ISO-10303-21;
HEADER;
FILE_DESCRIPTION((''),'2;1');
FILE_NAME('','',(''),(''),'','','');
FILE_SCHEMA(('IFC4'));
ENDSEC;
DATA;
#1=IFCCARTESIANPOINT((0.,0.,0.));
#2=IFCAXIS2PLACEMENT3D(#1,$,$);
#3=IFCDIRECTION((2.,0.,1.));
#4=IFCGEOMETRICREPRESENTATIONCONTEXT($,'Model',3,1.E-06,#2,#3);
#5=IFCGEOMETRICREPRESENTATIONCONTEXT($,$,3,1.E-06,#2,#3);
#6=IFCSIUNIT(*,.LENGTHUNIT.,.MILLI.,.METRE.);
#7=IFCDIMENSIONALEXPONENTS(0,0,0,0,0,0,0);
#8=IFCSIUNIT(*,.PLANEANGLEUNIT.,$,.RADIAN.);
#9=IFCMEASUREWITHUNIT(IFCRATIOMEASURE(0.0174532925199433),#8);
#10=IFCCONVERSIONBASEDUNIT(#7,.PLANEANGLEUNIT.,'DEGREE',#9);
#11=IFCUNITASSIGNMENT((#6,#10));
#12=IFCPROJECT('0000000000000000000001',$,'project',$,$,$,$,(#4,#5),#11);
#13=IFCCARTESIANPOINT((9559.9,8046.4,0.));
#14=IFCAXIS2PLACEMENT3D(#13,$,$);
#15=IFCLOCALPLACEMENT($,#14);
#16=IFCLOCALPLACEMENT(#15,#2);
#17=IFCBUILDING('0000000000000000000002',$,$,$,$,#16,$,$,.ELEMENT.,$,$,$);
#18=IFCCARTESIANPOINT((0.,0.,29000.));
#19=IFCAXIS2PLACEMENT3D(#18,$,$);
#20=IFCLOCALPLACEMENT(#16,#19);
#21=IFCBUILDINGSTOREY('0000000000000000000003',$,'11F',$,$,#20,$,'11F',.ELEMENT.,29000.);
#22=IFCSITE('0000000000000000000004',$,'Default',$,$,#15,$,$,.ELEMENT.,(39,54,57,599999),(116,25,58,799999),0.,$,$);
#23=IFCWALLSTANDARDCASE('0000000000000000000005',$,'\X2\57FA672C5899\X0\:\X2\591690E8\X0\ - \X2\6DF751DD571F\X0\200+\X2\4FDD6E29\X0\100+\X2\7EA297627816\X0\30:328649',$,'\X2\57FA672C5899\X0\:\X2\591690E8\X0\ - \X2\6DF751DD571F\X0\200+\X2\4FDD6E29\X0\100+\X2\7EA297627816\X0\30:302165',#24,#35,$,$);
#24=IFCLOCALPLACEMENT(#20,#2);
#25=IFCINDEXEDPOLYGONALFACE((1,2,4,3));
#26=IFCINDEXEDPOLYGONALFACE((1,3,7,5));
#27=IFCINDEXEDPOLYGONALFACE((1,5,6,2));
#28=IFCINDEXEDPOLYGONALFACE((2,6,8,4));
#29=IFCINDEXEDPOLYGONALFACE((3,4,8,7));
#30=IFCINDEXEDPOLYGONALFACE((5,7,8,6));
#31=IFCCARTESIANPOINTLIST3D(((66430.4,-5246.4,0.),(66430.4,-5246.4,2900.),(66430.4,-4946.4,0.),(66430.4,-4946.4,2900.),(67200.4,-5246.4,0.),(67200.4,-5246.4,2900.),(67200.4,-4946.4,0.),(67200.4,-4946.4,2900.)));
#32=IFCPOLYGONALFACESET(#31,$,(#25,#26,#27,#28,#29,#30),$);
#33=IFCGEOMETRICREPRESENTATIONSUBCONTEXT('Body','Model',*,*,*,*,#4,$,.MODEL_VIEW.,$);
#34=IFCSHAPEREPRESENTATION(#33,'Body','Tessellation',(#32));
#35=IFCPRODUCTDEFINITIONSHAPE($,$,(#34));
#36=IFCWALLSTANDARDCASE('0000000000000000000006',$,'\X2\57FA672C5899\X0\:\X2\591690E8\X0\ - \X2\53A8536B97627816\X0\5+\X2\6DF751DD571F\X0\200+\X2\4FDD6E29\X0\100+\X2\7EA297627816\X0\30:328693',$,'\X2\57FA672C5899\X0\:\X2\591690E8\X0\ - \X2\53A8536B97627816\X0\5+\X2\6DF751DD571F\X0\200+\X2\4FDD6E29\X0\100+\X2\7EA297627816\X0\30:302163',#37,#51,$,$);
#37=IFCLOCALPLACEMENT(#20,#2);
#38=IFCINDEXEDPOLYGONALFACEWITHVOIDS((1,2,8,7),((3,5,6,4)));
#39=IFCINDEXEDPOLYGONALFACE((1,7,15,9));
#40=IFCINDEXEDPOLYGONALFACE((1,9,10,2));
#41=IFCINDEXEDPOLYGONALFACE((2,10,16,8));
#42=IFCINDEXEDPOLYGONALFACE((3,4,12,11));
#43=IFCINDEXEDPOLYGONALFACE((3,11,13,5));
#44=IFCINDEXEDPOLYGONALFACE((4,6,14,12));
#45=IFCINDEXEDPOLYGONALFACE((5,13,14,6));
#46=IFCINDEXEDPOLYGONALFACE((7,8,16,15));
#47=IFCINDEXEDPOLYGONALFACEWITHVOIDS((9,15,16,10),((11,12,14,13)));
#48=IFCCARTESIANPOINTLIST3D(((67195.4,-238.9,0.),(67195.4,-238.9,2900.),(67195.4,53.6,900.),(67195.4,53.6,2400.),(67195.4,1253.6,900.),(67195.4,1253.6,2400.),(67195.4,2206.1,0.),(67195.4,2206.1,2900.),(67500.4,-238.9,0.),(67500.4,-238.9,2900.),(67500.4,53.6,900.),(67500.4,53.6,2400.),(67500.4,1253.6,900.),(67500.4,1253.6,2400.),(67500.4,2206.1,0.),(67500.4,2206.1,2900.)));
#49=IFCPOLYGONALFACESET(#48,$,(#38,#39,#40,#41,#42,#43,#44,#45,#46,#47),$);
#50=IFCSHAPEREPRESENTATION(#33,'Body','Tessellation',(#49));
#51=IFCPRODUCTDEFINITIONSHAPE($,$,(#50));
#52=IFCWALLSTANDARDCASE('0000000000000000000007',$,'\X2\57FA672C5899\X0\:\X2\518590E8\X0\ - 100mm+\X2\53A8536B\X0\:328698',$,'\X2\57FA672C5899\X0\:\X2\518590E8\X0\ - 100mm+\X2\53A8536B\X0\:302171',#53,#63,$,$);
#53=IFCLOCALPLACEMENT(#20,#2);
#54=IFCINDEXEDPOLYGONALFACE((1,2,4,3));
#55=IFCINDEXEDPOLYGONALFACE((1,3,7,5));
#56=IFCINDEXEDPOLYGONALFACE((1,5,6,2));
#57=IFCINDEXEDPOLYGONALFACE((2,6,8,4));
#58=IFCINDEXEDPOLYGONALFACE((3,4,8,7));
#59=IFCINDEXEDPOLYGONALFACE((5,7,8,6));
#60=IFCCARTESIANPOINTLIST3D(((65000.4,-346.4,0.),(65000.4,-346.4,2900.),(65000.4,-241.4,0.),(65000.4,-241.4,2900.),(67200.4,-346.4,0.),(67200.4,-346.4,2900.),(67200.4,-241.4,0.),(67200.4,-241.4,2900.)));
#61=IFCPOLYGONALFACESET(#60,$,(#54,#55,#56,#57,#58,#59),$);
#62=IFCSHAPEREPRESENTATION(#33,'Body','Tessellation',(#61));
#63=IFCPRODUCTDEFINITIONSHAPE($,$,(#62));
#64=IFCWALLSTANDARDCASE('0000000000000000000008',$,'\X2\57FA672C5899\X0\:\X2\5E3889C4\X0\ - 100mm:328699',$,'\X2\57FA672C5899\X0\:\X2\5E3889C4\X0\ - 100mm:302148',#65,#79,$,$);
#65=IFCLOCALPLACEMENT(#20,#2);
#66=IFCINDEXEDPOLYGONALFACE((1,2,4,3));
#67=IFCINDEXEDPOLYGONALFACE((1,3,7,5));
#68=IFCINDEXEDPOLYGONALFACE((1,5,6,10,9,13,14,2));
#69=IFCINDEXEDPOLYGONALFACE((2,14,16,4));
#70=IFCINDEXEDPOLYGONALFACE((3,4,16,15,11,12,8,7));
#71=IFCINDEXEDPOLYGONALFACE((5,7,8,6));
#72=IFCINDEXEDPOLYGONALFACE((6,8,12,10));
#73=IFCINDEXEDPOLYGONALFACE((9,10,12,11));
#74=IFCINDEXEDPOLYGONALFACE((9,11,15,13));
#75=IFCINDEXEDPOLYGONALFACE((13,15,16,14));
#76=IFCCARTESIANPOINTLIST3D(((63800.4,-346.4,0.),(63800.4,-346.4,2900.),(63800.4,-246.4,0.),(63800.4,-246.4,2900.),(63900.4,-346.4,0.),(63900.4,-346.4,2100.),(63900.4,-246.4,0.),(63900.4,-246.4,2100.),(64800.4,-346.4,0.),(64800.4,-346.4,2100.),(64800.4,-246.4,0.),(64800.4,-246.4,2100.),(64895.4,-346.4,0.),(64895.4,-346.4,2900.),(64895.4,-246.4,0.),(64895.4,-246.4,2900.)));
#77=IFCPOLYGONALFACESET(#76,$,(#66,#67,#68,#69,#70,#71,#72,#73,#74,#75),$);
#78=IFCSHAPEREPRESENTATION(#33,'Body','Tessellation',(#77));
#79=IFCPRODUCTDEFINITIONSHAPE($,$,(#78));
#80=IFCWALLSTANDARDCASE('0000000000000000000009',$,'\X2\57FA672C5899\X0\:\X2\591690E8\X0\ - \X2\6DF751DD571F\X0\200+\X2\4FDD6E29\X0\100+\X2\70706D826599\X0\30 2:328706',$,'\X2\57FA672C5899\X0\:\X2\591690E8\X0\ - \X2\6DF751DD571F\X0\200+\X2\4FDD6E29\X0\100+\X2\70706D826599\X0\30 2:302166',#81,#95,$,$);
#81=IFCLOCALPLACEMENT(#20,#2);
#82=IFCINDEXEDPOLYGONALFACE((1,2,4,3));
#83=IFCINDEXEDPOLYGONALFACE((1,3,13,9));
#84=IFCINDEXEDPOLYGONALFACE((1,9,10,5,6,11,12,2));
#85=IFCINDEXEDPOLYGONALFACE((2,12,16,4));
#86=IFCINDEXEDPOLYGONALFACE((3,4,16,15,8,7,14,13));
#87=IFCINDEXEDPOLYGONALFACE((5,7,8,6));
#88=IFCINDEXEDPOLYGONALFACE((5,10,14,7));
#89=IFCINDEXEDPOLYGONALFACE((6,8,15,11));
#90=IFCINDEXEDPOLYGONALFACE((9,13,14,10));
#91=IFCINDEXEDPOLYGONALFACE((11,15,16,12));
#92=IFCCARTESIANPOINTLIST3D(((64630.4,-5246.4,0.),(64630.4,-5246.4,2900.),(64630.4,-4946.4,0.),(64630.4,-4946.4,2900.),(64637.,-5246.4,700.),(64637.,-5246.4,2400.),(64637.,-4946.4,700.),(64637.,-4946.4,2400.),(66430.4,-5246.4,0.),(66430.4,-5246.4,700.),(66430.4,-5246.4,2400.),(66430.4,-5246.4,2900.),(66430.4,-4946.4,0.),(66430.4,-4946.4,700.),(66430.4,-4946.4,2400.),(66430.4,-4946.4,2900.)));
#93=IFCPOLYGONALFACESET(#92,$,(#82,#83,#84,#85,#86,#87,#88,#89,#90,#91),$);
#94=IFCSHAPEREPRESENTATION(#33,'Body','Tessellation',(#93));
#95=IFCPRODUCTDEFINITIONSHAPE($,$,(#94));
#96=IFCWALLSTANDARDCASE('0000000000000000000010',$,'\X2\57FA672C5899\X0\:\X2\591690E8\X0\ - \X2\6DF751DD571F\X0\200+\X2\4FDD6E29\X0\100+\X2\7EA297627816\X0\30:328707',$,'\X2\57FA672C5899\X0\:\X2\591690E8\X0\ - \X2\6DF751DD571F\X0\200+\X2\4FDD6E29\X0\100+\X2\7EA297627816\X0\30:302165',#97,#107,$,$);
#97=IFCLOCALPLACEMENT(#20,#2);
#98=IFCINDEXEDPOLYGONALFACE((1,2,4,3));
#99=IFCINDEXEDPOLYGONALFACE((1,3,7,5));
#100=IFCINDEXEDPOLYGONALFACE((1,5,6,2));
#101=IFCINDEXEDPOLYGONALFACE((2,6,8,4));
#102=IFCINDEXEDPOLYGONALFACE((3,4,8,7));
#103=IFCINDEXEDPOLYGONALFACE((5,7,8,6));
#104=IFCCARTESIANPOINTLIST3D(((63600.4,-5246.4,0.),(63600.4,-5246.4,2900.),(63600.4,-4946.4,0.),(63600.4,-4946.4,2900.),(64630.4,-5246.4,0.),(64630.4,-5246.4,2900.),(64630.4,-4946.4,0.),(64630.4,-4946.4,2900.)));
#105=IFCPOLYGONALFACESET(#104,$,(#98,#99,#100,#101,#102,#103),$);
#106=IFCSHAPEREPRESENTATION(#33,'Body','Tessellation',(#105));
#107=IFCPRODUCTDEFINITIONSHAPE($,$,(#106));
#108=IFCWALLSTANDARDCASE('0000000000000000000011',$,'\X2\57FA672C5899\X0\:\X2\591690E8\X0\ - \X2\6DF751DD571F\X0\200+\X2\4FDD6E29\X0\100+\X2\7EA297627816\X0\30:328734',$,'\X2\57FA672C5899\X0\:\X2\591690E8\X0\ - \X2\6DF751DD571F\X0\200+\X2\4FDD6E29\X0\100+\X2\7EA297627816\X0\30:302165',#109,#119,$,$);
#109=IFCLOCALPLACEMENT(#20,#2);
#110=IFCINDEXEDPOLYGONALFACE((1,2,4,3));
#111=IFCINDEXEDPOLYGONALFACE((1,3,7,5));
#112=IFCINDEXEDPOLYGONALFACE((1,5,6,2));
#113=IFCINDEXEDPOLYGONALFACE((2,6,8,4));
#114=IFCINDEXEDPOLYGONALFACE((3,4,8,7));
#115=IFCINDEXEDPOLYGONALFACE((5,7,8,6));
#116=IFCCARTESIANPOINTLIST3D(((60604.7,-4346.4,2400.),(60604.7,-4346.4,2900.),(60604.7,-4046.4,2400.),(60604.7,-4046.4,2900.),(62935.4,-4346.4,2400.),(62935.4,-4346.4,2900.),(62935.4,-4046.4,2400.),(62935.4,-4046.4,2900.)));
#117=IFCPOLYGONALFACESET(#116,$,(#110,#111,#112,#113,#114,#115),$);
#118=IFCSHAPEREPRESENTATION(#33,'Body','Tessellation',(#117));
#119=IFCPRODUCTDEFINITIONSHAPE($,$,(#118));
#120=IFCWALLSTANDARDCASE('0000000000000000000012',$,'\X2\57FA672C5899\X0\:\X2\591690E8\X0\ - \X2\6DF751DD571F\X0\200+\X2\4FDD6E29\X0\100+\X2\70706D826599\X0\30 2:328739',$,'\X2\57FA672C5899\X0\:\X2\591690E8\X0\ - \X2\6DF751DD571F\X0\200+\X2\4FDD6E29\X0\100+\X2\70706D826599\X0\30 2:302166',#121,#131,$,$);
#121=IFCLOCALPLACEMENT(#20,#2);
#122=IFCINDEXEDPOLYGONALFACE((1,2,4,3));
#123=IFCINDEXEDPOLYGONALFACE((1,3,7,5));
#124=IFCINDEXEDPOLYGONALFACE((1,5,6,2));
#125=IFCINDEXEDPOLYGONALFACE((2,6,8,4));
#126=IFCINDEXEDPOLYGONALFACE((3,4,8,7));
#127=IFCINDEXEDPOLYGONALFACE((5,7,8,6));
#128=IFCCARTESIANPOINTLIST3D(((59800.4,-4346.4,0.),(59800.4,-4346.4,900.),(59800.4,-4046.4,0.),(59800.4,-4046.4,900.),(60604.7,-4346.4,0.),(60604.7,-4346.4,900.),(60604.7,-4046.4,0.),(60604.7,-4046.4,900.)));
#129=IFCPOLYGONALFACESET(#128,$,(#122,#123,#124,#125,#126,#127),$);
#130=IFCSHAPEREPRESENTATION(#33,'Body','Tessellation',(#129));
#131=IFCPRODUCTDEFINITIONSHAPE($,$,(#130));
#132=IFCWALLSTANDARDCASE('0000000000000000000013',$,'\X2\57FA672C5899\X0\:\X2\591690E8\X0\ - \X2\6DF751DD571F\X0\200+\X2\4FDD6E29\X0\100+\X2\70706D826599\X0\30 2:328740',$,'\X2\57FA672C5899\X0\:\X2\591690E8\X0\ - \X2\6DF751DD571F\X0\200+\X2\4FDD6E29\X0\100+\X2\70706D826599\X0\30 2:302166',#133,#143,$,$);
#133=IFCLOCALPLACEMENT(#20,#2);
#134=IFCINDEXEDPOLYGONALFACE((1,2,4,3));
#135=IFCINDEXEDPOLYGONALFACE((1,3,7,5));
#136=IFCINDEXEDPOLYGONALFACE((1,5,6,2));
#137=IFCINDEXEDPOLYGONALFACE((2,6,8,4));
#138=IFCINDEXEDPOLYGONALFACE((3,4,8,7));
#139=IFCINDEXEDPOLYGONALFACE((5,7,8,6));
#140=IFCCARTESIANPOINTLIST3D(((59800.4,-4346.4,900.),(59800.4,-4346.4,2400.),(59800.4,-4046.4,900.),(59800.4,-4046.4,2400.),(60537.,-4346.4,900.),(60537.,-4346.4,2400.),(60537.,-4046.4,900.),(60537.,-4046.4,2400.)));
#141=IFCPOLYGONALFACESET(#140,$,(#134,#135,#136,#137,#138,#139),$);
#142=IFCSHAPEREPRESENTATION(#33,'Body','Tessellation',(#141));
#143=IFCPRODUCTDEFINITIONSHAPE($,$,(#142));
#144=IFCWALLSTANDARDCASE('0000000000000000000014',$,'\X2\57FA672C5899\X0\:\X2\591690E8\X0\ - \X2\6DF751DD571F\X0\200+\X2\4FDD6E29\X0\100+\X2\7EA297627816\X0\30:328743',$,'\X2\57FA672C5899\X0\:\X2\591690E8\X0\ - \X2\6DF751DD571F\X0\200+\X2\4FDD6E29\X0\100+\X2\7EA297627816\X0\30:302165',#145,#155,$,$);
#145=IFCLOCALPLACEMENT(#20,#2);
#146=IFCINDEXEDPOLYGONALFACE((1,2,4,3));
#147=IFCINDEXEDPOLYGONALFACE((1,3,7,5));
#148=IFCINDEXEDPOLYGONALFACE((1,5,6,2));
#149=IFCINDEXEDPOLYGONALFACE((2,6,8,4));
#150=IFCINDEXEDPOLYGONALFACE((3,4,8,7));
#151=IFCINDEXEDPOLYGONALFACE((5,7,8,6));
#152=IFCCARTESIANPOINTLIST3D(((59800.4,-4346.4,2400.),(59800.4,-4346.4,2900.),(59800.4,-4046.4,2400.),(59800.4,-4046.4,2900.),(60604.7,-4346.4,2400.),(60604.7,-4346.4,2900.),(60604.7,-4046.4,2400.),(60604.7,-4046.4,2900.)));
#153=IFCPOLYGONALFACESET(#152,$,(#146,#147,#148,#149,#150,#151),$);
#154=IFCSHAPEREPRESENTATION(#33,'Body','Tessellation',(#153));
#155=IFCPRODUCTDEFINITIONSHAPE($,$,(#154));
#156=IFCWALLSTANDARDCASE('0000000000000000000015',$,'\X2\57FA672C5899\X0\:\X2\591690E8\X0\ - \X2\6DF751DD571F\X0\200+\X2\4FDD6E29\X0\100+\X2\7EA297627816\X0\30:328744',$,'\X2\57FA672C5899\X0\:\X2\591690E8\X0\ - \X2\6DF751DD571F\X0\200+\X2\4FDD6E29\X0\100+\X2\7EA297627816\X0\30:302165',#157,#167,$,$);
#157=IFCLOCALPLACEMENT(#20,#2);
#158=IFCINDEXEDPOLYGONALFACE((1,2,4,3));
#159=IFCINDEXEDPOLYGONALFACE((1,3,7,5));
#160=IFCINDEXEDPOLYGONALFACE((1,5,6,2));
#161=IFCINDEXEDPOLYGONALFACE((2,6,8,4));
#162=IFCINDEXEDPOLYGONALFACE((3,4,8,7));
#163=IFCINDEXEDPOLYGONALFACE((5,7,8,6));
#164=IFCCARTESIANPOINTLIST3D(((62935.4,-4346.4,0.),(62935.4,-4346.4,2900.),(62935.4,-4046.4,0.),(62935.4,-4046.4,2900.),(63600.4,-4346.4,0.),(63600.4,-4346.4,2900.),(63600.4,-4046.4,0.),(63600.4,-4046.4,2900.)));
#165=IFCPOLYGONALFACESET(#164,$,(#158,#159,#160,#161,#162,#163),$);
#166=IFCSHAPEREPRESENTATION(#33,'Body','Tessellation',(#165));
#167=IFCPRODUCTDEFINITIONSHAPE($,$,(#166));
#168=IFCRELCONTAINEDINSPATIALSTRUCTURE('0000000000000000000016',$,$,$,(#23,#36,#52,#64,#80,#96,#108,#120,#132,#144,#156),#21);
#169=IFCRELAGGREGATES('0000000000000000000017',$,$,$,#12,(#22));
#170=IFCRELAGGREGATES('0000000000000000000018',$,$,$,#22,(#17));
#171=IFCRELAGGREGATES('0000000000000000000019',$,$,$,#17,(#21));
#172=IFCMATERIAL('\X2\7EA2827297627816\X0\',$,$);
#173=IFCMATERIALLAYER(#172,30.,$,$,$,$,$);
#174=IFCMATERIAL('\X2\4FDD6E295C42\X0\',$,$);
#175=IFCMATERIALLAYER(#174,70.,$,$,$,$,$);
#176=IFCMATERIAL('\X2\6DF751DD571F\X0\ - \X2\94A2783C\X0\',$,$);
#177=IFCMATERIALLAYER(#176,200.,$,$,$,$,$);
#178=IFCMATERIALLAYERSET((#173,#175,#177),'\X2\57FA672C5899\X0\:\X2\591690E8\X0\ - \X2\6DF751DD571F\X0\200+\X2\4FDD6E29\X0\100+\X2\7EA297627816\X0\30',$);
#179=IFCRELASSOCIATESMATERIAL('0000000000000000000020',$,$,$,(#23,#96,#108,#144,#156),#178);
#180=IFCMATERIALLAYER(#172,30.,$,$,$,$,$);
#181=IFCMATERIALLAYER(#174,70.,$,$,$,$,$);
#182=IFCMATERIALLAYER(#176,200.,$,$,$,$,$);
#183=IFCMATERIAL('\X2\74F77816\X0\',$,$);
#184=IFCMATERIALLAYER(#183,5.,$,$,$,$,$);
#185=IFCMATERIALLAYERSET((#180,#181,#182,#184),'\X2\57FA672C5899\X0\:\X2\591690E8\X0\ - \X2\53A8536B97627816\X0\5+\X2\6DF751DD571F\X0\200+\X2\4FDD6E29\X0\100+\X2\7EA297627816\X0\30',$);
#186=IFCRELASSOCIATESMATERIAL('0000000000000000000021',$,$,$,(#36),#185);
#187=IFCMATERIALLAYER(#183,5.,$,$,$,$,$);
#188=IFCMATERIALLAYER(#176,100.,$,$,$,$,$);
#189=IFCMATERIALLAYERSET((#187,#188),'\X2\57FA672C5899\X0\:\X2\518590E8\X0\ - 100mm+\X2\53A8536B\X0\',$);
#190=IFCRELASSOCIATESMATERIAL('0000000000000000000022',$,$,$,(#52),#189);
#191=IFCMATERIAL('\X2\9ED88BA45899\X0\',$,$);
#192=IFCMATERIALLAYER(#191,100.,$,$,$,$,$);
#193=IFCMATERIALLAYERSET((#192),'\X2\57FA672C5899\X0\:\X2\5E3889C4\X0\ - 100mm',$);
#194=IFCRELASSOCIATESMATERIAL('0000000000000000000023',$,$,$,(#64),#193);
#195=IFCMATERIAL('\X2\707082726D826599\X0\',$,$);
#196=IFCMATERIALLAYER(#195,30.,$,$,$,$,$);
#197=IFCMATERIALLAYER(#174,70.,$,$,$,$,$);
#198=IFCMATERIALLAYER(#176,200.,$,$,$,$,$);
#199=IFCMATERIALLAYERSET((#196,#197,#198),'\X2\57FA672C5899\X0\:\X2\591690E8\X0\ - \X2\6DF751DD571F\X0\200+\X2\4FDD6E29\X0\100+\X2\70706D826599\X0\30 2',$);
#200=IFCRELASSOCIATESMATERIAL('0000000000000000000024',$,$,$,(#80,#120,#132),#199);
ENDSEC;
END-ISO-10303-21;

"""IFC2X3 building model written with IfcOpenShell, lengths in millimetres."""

from ifc_helpers import new_model, entity, si_unit, converted_unit, direction, frame, frame_2d, origin, place, context, subcontext, project, spatial, rectangle, extrude, material, layer, layer_set, layer_usage, element, save


model = new_model("IFC2X3")

# Units and contexts
model_context = context("Model", 3, precision=1e-06, world=origin(), true_north=direction((2.0, 0.0, 1.0)))
context_of_model = context(None, 3, precision=1e-06, world=origin(), true_north=direction((2.0, 0.0, 1.0)))
body_context = subcontext(model_context, "Body", "Model", "MODEL_VIEW")
ifc_project = project(units=[si_unit("LENGTHUNIT", "METRE", prefix="MILLI"), converted_unit("PLANEANGLEUNIT", "DEGREE", entity("IfcRatioMeasure", 0.0174532925199433), si_unit("PLANEANGLEUNIT", "RADIAN"), dimensions=[0, 0, 0, 0, 0, 0, 0])], contexts=[model_context, context_of_model])

# Site, building, storey
site_placement = place(None, frame((9559.9, 8046.4, 0.0)))
site = spatial("IfcSite", under=ifc_project, at=site_placement, Name="Default", CompositionType="ELEMENT", RefLatitude=(39, 54, 57, 599999), RefLongitude=(116, 25, 58, 799999), RefElevation=0.0)
building_placement = place(site_placement, origin())
building = spatial("IfcBuilding", under=site, at=building_placement, CompositionType="ELEMENT")
storey_placement = place(building_placement, frame((0.0, 0.0, 29000.0)))
storey = spatial("IfcBuildingStorey", under=building, at=storey_placement, Name="11F", LongName="11F", CompositionType="ELEMENT", Elevation=29000.0)

# Shared definitions
ifc_material_1 = material(Name="默认墙")

# Shared definitions
ifc_material_2 = material(Name="保温层")
ifc_material_3 = material(Name="混凝土 - 钢砼")
ifc_material_4 = material(Name="灰色涂料")
ifc_layer_1 = layer(ifc_material_4, 30.0)
ifc_layer_2 = layer(ifc_material_2, 70.0)
ifc_layer_3 = layer(ifc_material_3, 200.0)
ifc_layer_set_1 = layer_set([ifc_layer_1, ifc_layer_2, ifc_layer_3], Name="基本墙:外部 - 混凝土200+保温100+灰涂料30 2")

# Shared definitions
ifc_material_5 = material(Name="红色面砖")
ifc_layer_4 = layer(ifc_material_5, 30.0)
ifc_layer_5 = layer(ifc_material_2, 70.0)
ifc_layer_6 = layer(ifc_material_3, 200.0)
ifc_layer_set_2 = layer_set([ifc_layer_4, ifc_layer_5, ifc_layer_6], Name="基本墙:外部 - 混凝土200+保温100+红面砖30")

# Wall
ifc_layer_usage_1 = layer_usage(ifc_layer_set_2, "AXIS2", "NEGATIVE", 150.0)
wall_1_placement = place(storey_placement, frame((67200.4, -5096.4, 0.0), z_axis=(0.0, 0.0, 1.0), x_axis=(-1.0, 0.0, 0.0)))
element("IfcWallStandardCase", 1, at=wall_1_placement, inside=storey, material=ifc_layer_usage_1, Name="基本墙:外部 - 混凝土200+保温100+红面砖30:328649", ObjectType="基本墙:外部 - 混凝土200+保温100+红面砖30:302165", context=body_context, shape_type="SweptSolid", body=[
    extrude(rectangle(XDim=770.0, YDim=300.0, at=frame_2d((385.0, 0.0), x_axis=(-1.0, 0.0))), origin(), (0.0, 0.0, 1.0), 2900.0),
])

# Wall, opening
ifc_layer_7 = layer(ifc_material_5, 30.0)
ifc_layer_8 = layer(ifc_material_2, 70.0)
ifc_layer_9 = layer(ifc_material_3, 200.0)
ifc_material_6 = material(Name="瓷砖")
ifc_layer_10 = layer(ifc_material_6, 5.0)
ifc_layer_set_3 = layer_set([ifc_layer_7, ifc_layer_8, ifc_layer_9, ifc_layer_10], Name="基本墙:外部 - 厨卫面砖5+混凝土200+保温100+红面砖30")
ifc_layer_usage_2 = layer_usage(ifc_layer_set_3, "AXIS2", "POSITIVE", -152.5)
wall_2_placement = place(storey_placement, frame((67347.9, -238.9, 0.0), z_axis=(0.0, 0.0, 1.0), x_axis=(0.0, 1.0, 0.0)))
wall_2 = element("IfcWallStandardCase", 2, at=wall_2_placement, inside=storey, material=ifc_layer_usage_2, Name="基本墙:外部 - 厨卫面砖5+混凝土200+保温100+红面砖30:328693", ObjectType="基本墙:外部 - 厨卫面砖5+混凝土200+保温100+红面砖30:302163", context=body_context, shape_type="SweptSolid", body=[
    extrude(rectangle(XDim=2445.0, YDim=305.0, at=frame_2d((1222.5, 0.0), x_axis=(-1.0, 0.0))), origin(), (0.0, 0.0, 1.0), 2900.0),
])
opening_1_placement = place(wall_2_placement, frame((1492.5, 152.5, 900.0)))
element("IfcOpeningElement", 3, at=opening_1_placement, cuts=wall_2, ObjectType="Opening", context=body_context, shape_type="SweptSolid", body=[
    extrude(rectangle(XDim=1500.0, YDim=1200.0, at=frame_2d((750.0, 600.0), x_axis=(1.0, 0.0))), frame((0.0, 0.0, 0.0), z_axis=(0.0, -1.0, 0.0), x_axis=(0.0, 0.0, 1.0)), (0.0, 0.0, 1.0), 305.0),
])

# Wall
ifc_layer_11 = layer(ifc_material_6, 5.0)
ifc_layer_12 = layer(ifc_material_3, 100.0)
ifc_layer_set_4 = layer_set([ifc_layer_11, ifc_layer_12], Name="基本墙:内部 - 100mm+厨卫")
ifc_layer_usage_3 = layer_usage(ifc_layer_set_4, "AXIS2", "POSITIVE", -52.5)
wall_3_placement = place(storey_placement, frame((67200.4, -293.9, 0.0), z_axis=(0.0, 0.0, 1.0), x_axis=(-1.0, 0.0, 0.0)))
element("IfcWallStandardCase", 4, at=wall_3_placement, inside=storey, material=ifc_layer_usage_3, Name="基本墙:内部 - 100mm+厨卫:328698", ObjectType="基本墙:内部 - 100mm+厨卫:302171", context=body_context, shape_type="SweptSolid", body=[
    extrude(rectangle(XDim=2200.0, YDim=105.0, at=frame_2d((1100.0, 0.0), x_axis=(-1.0, 0.0))), origin(), (0.0, 0.0, 1.0), 2900.0),
])

# Walls, openings
ifc_layer_13 = layer(ifc_material_1, 100.0)
ifc_layer_set_5 = layer_set([ifc_layer_13], Name="基本墙:常规 - 100mm")
ifc_layer_usage_4 = layer_usage(ifc_layer_set_5, "AXIS2", "POSITIVE", -50.0)
wall_4_placement = place(storey_placement, frame((64895.4, -296.4, 0.0), z_axis=(0.0, 0.0, 1.0), x_axis=(-1.0, 0.0, 0.0)))
wall_4 = element("IfcWallStandardCase", 5, at=wall_4_placement, inside=storey, material=ifc_layer_usage_4, Name="基本墙:常规 - 100mm:328699", ObjectType="基本墙:常规 - 100mm:302148", context=body_context, shape_type="SweptSolid", body=[
    extrude(rectangle(XDim=1095.0, YDim=100.0, at=frame_2d((547.5, 0.0), x_axis=(-1.0, 0.0))), origin(), (0.0, 0.0, 1.0), 2900.0),
])
opening_2_placement = place(wall_4_placement, frame((95.0, -50.0, 0.0)))
element("IfcOpeningElement", 6, at=opening_2_placement, cuts=wall_4, ObjectType="Opening", context=body_context, shape_type="SweptSolid", body=[
    extrude(rectangle(XDim=2100.0, YDim=900.0, at=frame_2d((1050.0, 450.0), x_axis=(1.0, 0.0))), frame((0.0, 0.0, 0.0), z_axis=(0.0, 1.0, 0.0), x_axis=(0.0, 0.0, 1.0)), (0.0, 0.0, 1.0), 100.0),
])
ifc_layer_usage_5 = layer_usage(ifc_layer_set_1, "AXIS2", "NEGATIVE", 150.0)
wall_5_placement = place(storey_placement, frame((66430.4, -5096.4, 0.0), z_axis=(0.0, 0.0, 1.0), x_axis=(-1.0, 0.0, 0.0)))
wall_5 = element("IfcWallStandardCase", 7, at=wall_5_placement, inside=storey, material=ifc_layer_usage_5, Name="基本墙:外部 - 混凝土200+保温100+灰涂料30 2:328706", ObjectType="基本墙:外部 - 混凝土200+保温100+灰涂料30 2:302166", context=body_context, shape_type="SweptSolid", body=[
    extrude(rectangle(XDim=1800.0, YDim=300.0, at=frame_2d((900.0, 0.0), x_axis=(-1.0, 0.0))), origin(), (0.0, 0.0, 1.0), 2900.0),
])
opening_3_placement = place(wall_5_placement, frame((-6.6, -150.0, 700.0)))
element("IfcOpeningElement", 8, at=opening_3_placement, cuts=wall_5, ObjectType="Opening", context=body_context, shape_type="SweptSolid", body=[
    extrude(rectangle(XDim=1700.0, YDim=1800.0, at=frame_2d((850.0, 900.0), x_axis=(1.0, 0.0))), frame((0.0, 0.0, 0.0), z_axis=(0.0, 1.0, 0.0), x_axis=(0.0, 0.0, 1.0)), (0.0, 0.0, 1.0), 300.0),
])

# Walls
ifc_layer_usage_6 = layer_usage(ifc_layer_set_2, "AXIS2", "NEGATIVE", 150.0)
wall_6_placement = place(storey_placement, frame((64630.4, -5096.4, 0.0), z_axis=(0.0, 0.0, 1.0), x_axis=(-1.0, 0.0, 0.0)))
element("IfcWallStandardCase", 9, at=wall_6_placement, inside=storey, material=ifc_layer_usage_6, Name="基本墙:外部 - 混凝土200+保温100+红面砖30:328707", ObjectType="基本墙:外部 - 混凝土200+保温100+红面砖30:302165", context=body_context, shape_type="SweptSolid", body=[
    extrude(rectangle(XDim=1030.0, YDim=300.0, at=frame_2d((515.0, 0.0), x_axis=(-1.0, 0.0))), origin(), (0.0, 0.0, 1.0), 2900.0),
])
ifc_layer_usage_7 = layer_usage(ifc_layer_set_2, "AXIS2", "NEGATIVE", 150.0)
wall_7_placement = place(storey_placement, frame((62935.4, -4196.4, 2400.0), z_axis=(0.0, 0.0, 1.0), x_axis=(-1.0, 0.0, 0.0)))
element("IfcWallStandardCase", 10, at=wall_7_placement, inside=storey, material=ifc_layer_usage_7, Name="基本墙:外部 - 混凝土200+保温100+红面砖30:328734", ObjectType="基本墙:外部 - 混凝土200+保温100+红面砖30:302165", context=body_context, shape_type="SweptSolid", body=[
    extrude(rectangle(XDim=2330.6, YDim=300.0, at=frame_2d((1165.3, 0.0), x_axis=(-1.0, 0.0))), origin(), (0.0, 0.0, 1.0), 500.0),
])

# Walls
ifc_layer_usage_8 = layer_usage(ifc_layer_set_1, "AXIS2", "NEGATIVE", 150.0)
wall_8_placement = place(storey_placement, frame((60604.7, -4196.4, 0.0), z_axis=(0.0, 0.0, 1.0), x_axis=(-1.0, 0.0, 0.0)))
element("IfcWallStandardCase", 11, at=wall_8_placement, inside=storey, material=ifc_layer_usage_8, Name="基本墙:外部 - 混凝土200+保温100+灰涂料30 2:328739", ObjectType="基本墙:外部 - 混凝土200+保温100+灰涂料30 2:302166", context=body_context, shape_type="SweptSolid", body=[
    extrude(rectangle(XDim=804.4, YDim=300.0, at=frame_2d((402.2, 0.0), x_axis=(-1.0, 0.0))), origin(), (0.0, 0.0, 1.0), 900.0),
])
ifc_layer_usage_9 = layer_usage(ifc_layer_set_1, "AXIS2", "NEGATIVE", 150.0)
wall_9_placement = place(storey_placement, frame((60537.0, -4196.4, 900.0), z_axis=(0.0, 0.0, 1.0), x_axis=(-1.0, 0.0, 0.0)))
element("IfcWallStandardCase", 12, at=wall_9_placement, inside=storey, material=ifc_layer_usage_9, Name="基本墙:外部 - 混凝土200+保温100+灰涂料30 2:328740", ObjectType="基本墙:外部 - 混凝土200+保温100+灰涂料30 2:302166", context=body_context, shape_type="SweptSolid", body=[
    extrude(rectangle(XDim=736.6, YDim=300.0, at=frame_2d((368.3, 0.0), x_axis=(-1.0, 0.0))), origin(), (0.0, 0.0, 1.0), 1500.0),
])
ifc_layer_usage_10 = layer_usage(ifc_layer_set_2, "AXIS2", "NEGATIVE", 150.0)
wall_10_placement = place(storey_placement, frame((60604.7, -4196.4, 2400.0), z_axis=(0.0, 0.0, 1.0), x_axis=(-1.0, 0.0, 0.0)))
element("IfcWallStandardCase", 13, at=wall_10_placement, inside=storey, material=ifc_layer_usage_10, Name="基本墙:外部 - 混凝土200+保温100+红面砖30:328743", ObjectType="基本墙:外部 - 混凝土200+保温100+红面砖30:302165", context=body_context, shape_type="SweptSolid", body=[
    extrude(rectangle(XDim=804.4, YDim=300.0, at=frame_2d((402.2, 0.0), x_axis=(-1.0, 0.0))), origin(), (0.0, 0.0, 1.0), 500.0),
])
ifc_layer_usage_11 = layer_usage(ifc_layer_set_2, "AXIS2", "NEGATIVE", 150.0)
wall_11_placement = place(storey_placement, frame((63600.4, -4196.4, 0.0), z_axis=(0.0, 0.0, 1.0), x_axis=(-1.0, 0.0, 0.0)))
element("IfcWallStandardCase", 14, at=wall_11_placement, inside=storey, material=ifc_layer_usage_11, Name="基本墙:外部 - 混凝土200+保温100+红面砖30:328744", ObjectType="基本墙:外部 - 混凝土200+保温100+红面砖30:302165", context=body_context, shape_type="SweptSolid", body=[
    extrude(rectangle(XDim=665.0, YDim=300.0, at=frame_2d((332.5, 0.0), x_axis=(-1.0, 0.0))), origin(), (0.0, 0.0, 1.0), 2900.0),
])

save(model, "model.ifc")
